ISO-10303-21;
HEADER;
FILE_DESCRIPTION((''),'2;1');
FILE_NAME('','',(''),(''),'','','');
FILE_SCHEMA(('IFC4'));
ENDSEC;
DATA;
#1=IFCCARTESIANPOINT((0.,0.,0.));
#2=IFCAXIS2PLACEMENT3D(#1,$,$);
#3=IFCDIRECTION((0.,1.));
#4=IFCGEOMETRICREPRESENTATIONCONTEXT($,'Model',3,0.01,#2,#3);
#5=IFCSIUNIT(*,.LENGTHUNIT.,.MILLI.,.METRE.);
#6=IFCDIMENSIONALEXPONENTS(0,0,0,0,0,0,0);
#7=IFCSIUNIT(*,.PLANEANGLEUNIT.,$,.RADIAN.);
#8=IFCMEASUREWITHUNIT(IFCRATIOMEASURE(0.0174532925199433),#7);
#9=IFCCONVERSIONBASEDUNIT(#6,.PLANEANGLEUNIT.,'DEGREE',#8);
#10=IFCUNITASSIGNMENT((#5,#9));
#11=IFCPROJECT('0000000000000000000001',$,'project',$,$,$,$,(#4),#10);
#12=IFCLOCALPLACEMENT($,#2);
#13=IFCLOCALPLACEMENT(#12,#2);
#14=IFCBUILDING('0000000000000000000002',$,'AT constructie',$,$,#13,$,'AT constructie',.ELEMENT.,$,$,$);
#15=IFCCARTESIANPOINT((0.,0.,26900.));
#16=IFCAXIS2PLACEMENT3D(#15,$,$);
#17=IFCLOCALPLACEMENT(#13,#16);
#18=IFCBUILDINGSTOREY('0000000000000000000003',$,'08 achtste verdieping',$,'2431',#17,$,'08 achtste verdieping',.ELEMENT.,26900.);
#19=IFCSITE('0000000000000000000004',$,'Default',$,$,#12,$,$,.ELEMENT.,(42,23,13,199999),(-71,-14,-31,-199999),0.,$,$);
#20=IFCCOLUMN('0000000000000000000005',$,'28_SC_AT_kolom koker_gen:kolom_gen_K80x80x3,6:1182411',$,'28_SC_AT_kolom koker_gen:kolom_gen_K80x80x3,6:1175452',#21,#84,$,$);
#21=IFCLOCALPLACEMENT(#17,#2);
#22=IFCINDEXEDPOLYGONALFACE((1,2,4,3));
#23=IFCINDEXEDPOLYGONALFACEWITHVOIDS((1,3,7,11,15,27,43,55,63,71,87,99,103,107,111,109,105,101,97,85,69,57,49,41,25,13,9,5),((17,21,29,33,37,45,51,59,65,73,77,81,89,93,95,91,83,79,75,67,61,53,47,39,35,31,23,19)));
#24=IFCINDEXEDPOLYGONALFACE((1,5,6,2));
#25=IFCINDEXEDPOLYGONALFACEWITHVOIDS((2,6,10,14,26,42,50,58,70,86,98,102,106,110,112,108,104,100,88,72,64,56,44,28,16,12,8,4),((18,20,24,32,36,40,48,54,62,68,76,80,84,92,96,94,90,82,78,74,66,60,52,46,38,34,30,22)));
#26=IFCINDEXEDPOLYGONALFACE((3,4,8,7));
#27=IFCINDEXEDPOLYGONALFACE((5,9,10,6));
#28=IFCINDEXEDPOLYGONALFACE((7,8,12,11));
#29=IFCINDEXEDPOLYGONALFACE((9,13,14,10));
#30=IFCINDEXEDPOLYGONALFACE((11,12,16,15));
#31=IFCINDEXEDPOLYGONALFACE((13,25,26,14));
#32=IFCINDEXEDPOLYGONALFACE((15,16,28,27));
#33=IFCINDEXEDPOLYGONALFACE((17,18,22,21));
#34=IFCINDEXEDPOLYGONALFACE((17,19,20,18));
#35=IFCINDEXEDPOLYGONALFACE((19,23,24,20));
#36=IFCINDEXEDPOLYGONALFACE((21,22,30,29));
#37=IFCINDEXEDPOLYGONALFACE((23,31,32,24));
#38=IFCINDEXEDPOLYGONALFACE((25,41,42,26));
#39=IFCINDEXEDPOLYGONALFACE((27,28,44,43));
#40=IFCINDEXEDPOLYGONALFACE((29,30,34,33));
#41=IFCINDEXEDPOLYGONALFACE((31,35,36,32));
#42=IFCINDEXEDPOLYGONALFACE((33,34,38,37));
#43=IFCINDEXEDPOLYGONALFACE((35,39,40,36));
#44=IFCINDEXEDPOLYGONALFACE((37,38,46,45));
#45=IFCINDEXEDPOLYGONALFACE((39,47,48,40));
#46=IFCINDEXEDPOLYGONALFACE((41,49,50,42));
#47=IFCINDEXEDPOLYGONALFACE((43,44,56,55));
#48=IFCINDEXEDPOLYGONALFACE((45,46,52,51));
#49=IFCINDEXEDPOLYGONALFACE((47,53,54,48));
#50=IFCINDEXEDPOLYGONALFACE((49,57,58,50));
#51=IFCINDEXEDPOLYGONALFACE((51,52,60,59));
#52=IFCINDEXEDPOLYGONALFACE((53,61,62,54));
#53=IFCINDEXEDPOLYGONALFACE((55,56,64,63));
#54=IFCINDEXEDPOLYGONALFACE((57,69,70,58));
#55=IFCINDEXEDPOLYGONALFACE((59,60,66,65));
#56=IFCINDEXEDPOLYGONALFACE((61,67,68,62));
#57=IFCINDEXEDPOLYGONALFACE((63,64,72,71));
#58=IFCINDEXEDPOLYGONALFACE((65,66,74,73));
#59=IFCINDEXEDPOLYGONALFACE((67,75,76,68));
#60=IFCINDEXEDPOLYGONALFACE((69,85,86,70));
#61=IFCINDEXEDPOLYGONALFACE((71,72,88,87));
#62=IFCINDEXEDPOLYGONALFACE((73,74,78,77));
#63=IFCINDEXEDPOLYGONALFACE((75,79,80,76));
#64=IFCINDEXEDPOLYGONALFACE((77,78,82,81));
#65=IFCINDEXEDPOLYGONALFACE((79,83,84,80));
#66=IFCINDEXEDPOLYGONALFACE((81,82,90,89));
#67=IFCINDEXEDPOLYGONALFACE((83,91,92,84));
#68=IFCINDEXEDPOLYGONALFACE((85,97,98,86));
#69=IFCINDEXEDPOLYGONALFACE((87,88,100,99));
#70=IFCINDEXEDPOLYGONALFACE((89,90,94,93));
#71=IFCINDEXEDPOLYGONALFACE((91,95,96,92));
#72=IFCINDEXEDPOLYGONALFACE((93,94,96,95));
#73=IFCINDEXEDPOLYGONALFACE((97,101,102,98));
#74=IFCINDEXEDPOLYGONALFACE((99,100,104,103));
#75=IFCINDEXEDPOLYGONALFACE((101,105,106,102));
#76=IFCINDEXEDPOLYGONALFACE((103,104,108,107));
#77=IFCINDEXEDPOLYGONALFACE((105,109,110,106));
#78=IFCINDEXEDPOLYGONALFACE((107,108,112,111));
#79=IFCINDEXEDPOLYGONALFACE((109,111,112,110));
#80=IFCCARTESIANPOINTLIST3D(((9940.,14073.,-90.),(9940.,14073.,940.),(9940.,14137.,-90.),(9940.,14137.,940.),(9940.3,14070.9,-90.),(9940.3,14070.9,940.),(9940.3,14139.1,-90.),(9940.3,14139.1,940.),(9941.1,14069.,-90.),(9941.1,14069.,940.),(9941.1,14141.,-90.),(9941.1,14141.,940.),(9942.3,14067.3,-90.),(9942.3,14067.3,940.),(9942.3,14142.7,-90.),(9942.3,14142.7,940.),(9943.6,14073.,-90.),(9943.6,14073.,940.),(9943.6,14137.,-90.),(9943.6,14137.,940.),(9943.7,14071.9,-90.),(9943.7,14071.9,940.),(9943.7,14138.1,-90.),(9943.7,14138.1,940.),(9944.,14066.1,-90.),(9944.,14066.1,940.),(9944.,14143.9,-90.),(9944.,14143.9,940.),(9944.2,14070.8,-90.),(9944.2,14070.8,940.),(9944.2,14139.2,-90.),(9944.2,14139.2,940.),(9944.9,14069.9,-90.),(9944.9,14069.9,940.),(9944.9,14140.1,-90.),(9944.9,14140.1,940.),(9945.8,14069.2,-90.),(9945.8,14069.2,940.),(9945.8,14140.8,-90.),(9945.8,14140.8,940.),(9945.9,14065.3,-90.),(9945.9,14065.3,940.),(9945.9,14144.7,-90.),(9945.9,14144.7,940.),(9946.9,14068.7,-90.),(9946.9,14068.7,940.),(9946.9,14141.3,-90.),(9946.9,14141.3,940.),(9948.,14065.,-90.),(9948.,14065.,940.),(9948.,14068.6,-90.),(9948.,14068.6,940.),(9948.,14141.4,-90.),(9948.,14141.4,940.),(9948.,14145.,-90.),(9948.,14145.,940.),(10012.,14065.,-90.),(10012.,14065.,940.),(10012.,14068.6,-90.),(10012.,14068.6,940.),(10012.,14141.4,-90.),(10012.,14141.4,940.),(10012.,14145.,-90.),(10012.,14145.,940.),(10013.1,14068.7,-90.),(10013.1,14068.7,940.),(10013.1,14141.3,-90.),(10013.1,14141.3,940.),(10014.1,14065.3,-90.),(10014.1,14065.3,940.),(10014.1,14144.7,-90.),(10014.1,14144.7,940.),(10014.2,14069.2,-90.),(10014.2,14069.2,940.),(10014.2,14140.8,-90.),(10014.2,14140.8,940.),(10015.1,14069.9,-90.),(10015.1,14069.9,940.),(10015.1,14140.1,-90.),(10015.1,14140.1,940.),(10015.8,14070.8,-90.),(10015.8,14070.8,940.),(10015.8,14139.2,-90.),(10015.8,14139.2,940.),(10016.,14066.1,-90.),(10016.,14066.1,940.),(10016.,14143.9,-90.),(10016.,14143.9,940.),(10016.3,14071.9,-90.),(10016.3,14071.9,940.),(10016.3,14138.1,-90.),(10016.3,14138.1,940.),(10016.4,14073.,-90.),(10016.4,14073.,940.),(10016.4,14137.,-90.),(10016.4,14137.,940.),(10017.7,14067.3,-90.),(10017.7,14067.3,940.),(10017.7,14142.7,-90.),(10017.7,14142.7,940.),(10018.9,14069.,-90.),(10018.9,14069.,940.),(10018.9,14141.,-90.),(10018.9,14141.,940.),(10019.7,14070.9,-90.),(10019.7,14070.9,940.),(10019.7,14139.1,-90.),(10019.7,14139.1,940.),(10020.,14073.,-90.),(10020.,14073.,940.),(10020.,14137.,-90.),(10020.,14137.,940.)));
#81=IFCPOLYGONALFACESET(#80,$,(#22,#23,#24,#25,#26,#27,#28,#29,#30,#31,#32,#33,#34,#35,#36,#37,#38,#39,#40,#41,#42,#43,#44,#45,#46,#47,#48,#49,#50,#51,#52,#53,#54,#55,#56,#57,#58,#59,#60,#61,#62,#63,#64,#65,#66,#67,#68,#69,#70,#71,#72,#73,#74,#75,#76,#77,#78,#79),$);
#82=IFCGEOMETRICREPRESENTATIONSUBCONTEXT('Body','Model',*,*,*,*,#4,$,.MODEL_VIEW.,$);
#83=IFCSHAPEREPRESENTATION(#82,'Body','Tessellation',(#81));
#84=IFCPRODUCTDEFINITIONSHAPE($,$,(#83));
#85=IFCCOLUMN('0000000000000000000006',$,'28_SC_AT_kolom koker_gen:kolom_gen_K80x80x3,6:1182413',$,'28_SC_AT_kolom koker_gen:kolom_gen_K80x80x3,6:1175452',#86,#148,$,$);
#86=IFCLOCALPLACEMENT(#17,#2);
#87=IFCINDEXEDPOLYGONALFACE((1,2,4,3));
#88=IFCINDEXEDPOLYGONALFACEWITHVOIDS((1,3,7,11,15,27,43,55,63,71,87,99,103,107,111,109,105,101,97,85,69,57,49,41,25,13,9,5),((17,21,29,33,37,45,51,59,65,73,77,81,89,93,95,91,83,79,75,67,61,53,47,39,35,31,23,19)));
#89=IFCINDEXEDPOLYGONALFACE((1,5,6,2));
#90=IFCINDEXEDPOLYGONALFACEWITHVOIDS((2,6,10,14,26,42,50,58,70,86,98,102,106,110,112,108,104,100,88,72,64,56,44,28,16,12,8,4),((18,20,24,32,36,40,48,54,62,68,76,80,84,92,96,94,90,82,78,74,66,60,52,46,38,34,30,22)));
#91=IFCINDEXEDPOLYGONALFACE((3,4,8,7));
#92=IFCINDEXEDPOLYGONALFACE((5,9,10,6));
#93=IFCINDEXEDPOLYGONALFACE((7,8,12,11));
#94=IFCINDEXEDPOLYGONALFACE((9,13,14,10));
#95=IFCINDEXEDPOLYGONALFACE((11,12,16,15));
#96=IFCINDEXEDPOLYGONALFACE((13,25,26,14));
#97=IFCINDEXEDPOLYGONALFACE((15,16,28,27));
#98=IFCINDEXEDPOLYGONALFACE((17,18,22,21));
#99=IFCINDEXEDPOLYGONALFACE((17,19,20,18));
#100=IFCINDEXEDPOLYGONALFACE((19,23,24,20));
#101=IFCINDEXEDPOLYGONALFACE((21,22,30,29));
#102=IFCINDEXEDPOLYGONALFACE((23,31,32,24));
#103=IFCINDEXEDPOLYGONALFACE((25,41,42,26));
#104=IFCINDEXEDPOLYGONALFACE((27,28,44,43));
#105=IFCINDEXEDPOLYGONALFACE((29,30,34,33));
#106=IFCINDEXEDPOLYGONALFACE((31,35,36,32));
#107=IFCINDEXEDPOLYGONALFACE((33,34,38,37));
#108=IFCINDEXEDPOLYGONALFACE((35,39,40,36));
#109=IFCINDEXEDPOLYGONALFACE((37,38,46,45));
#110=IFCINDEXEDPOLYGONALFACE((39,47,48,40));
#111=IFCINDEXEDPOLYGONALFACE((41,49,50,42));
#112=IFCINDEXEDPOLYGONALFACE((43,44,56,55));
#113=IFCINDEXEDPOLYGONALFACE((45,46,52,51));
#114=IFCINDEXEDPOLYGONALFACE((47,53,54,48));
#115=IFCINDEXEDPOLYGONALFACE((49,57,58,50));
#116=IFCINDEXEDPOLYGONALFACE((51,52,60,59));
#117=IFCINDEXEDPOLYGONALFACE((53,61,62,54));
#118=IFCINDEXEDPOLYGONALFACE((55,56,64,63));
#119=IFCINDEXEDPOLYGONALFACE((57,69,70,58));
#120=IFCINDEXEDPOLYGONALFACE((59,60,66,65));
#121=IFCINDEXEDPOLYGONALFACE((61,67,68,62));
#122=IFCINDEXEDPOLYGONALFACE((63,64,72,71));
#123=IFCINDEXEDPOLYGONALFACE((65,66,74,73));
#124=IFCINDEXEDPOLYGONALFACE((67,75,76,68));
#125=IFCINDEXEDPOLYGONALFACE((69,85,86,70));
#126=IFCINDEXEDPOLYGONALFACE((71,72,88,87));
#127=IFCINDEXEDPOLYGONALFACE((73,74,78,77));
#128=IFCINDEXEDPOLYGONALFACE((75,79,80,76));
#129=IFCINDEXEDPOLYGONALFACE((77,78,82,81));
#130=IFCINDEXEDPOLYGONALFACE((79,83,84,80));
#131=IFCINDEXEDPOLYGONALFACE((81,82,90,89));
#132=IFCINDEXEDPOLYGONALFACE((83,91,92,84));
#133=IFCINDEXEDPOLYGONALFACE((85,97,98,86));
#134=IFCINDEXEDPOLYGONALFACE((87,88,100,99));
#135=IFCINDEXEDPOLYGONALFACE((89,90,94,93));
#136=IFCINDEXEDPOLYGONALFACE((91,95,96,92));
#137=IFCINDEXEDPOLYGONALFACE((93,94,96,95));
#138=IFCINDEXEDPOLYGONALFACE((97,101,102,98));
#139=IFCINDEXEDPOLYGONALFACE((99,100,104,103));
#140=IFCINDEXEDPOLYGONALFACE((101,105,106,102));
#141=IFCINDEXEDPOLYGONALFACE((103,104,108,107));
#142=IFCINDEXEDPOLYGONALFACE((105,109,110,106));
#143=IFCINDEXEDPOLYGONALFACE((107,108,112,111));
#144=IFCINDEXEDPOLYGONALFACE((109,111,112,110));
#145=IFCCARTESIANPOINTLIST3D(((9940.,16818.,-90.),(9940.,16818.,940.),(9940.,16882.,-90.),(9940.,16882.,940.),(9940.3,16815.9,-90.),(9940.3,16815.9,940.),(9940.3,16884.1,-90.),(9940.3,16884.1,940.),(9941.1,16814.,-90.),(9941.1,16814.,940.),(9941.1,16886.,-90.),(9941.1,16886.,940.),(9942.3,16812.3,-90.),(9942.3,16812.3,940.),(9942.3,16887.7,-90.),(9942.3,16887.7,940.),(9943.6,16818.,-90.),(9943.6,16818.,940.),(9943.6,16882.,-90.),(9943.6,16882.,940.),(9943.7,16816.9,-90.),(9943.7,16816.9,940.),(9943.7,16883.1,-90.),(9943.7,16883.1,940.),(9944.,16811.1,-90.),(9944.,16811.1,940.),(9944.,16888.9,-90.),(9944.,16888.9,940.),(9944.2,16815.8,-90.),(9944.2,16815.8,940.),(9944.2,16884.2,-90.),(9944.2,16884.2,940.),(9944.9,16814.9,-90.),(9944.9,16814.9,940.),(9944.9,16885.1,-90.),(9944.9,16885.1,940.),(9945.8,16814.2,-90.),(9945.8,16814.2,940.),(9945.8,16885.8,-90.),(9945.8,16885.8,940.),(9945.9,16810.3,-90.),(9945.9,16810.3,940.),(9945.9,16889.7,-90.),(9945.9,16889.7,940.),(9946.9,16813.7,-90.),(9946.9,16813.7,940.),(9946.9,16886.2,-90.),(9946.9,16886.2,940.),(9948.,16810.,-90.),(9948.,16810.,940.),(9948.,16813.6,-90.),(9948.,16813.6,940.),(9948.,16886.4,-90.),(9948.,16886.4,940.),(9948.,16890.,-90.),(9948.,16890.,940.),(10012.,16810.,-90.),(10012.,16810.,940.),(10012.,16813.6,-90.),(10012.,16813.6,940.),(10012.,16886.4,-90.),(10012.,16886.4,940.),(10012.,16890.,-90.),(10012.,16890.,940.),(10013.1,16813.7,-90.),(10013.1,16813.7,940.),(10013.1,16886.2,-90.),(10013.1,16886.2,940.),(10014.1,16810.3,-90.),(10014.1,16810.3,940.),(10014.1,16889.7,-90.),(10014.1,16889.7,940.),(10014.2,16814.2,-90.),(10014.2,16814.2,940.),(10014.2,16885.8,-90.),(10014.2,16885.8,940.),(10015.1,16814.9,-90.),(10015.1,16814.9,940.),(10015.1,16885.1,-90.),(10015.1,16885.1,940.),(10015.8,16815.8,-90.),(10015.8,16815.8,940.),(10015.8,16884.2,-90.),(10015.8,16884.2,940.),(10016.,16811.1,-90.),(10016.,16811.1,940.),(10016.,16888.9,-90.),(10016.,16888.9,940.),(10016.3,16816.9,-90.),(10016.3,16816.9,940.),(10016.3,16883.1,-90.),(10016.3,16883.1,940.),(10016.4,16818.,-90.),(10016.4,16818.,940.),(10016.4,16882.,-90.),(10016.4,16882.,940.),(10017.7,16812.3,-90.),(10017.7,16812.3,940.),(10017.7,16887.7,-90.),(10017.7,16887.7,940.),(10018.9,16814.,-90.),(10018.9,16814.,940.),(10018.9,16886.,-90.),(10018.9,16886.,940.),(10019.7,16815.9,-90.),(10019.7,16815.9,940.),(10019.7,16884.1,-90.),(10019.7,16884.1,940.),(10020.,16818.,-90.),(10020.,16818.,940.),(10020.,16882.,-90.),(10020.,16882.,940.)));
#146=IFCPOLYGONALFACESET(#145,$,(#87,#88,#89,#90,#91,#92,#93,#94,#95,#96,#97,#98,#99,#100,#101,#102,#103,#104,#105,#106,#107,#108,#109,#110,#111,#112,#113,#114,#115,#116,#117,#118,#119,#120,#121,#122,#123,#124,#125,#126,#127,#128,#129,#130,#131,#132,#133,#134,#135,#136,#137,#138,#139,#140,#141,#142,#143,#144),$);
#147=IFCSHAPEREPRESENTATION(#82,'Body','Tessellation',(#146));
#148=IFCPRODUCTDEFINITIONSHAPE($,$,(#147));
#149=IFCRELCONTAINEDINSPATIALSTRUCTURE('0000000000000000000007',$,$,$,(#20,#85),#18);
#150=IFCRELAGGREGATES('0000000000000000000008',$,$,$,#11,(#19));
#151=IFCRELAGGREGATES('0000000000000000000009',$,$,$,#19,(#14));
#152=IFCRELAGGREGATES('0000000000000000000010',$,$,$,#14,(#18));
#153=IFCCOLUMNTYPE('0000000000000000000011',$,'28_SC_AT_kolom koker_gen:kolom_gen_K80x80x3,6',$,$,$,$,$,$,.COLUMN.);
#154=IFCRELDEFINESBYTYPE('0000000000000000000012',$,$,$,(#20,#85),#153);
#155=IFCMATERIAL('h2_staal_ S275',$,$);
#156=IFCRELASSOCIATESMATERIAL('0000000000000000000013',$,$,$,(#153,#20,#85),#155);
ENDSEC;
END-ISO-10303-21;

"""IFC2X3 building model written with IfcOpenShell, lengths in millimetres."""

from ifc_helpers import new_model, entity, si_unit, converted_unit, direction, frame, frame_2d, origin, place, context, subcontext, project, spatial, polyline, circle_curve, parameter, trimmed, segment, composite_curve, outline, extrude, source, transform, mapped, material, type_object, type_shapes, element, save


model = new_model("IFC2X3")

# Units and contexts
model_context = context("Model", 3, precision=0.01, world=origin(), true_north=direction((0.0, 1.0)))
body_context = subcontext(model_context, "Body", "Model", "MODEL_VIEW")
ifc_project = project(units=[si_unit("LENGTHUNIT", "METRE", prefix="MILLI"), converted_unit("PLANEANGLEUNIT", "DEGREE", entity("IfcRatioMeasure", 0.0174532925199433), si_unit("PLANEANGLEUNIT", "RADIAN"), dimensions=[0, 0, 0, 0, 0, 0, 0])], contexts=[model_context])

# Site, building, storey
site_placement = place(None, origin())
site = spatial("IfcSite", under=ifc_project, at=site_placement, Name="Default", CompositionType="ELEMENT", RefLatitude=(42, 23, 13, 199999), RefLongitude=(-71, -14, -31, -199999), RefElevation=0.0)
building_placement = place(site_placement, origin())
building = spatial("IfcBuilding", under=site, at=building_placement, Name="AT constructie", LongName="AT constructie", CompositionType="ELEMENT")
storey_placement = place(building_placement, frame((0.0, 0.0, 26900.0)))
storey = spatial("IfcBuildingStorey", under=building, at=storey_placement, Name="08 achtste verdieping", ObjectType="2431", LongName="08 achtste verdieping", CompositionType="ELEMENT", Elevation=26900.0)

# Columns
ifc_material_1 = material(Name="h2_staal_ S275")
column_type_1 = type_object("IfcColumnType", Name="28_SC_AT_kolom koker_gen:kolom_gen_K80x80x3,6", PredefinedType="COLUMN", material=ifc_material_1)
shared_shape_1 = source(origin(), body_context, "Body", "SweptSolid", [
    extrude(outline(composite_curve([segment(trimmed(circle_curve(frame_2d((32.0, 32.0), x_axis=(1.0, 0.0)), 8.0), [parameter(360.0)], [parameter(90.0)], True, "PARAMETER"), True, "CONTINUOUS"), segment(polyline([(32.0, 40.0), (-32.0, 40.0)]), True, "CONTINUOUS"), segment(trimmed(circle_curve(frame_2d((-32.0, 32.0), x_axis=(1.0, 0.0)), 8.0), [parameter(90.0)], [parameter(180.0)], True, "PARAMETER"), True, "CONTINUOUS"), segment(polyline([(-40.0, 32.0), (-40.0, -32.0)]), True, "CONTINUOUS"), segment(trimmed(circle_curve(frame_2d((-32.0, -32.0), x_axis=(1.0, 0.0)), 8.0), [parameter(180.0)], [parameter(270.0)], True, "PARAMETER"), True, "CONTINUOUS"), segment(polyline([(-32.0, -40.0), (32.0, -40.0)]), True, "CONTINUOUS"), segment(trimmed(circle_curve(frame_2d((32.0, -32.0), x_axis=(1.0, 0.0)), 8.0), [parameter(270.0)], [parameter(0.0)], True, "PARAMETER"), True, "CONTINUOUS"), segment(polyline([(40.0, -32.0), (40.0, 32.0)]), True, "CONTINUOUS")], self_intersect=False), holes=[composite_curve([segment(polyline([(-32.0, 36.4), (32.0, 36.4)]), True, "CONTINUOUS"), segment(trimmed(circle_curve(frame_2d((32.0, 32.0), x_axis=(1.0, 0.0)), 4.4), [parameter(360.0)], [parameter(90.0)], True, "PARAMETER"), False, "CONTINUOUS"), segment(polyline([(36.4, 32.0), (36.4, -32.0)]), True, "CONTINUOUS"), segment(trimmed(circle_curve(frame_2d((32.0, -32.0), x_axis=(1.0, 0.0)), 4.4), [parameter(270.0)], [parameter(360.0)], True, "PARAMETER"), False, "CONTINUOUS"), segment(polyline([(32.0, -36.4), (-32.0, -36.4)]), True, "CONTINUOUS"), segment(trimmed(circle_curve(frame_2d((-32.0, -32.0), x_axis=(1.0, 0.0)), 4.4), [parameter(180.0)], [parameter(270.0)], True, "PARAMETER"), False, "CONTINUOUS"), segment(polyline([(-36.4, -32.0), (-36.4, 32.0)]), True, "CONTINUOUS"), segment(trimmed(circle_curve(frame_2d((-32.0, 32.0), x_axis=(1.0, 0.0)), 4.4), [parameter(90.0)], [parameter(180.0)], True, "PARAMETER"), False, "CONTINUOUS")], self_intersect=False)]), frame((0.0, 0.0, 26810.0), z_axis=(0.0, 0.0, 1.0), x_axis=(-1.0, 0.0, 0.0)), (0.0, 0.0, 1.0), 1030.0),
])
type_shapes(column_type_1, [shared_shape_1])
for number, where, name in (
    (1, (9980.0, 14105.0, -26900.0), "28_SC_AT_kolom koker_gen:kolom_gen_K80x80x3,6:1182411"),
    (2, (9980.0, 16850.0, -26900.0), "28_SC_AT_kolom koker_gen:kolom_gen_K80x80x3,6:1182413"),
):
    element("IfcColumn", number, at=place(storey_placement, frame(where)), inside=storey, type_object=column_type_1, material=ifc_material_1, Name=name, ObjectType="28_SC_AT_kolom koker_gen:kolom_gen_K80x80x3,6:1175452", context=body_context, shape_type="MappedRepresentation", body=[
        mapped(shared_shape_1, transform((0.0, 0.0, 0.0), scale=1.0)),
    ])

save(model, "model.ifc")
